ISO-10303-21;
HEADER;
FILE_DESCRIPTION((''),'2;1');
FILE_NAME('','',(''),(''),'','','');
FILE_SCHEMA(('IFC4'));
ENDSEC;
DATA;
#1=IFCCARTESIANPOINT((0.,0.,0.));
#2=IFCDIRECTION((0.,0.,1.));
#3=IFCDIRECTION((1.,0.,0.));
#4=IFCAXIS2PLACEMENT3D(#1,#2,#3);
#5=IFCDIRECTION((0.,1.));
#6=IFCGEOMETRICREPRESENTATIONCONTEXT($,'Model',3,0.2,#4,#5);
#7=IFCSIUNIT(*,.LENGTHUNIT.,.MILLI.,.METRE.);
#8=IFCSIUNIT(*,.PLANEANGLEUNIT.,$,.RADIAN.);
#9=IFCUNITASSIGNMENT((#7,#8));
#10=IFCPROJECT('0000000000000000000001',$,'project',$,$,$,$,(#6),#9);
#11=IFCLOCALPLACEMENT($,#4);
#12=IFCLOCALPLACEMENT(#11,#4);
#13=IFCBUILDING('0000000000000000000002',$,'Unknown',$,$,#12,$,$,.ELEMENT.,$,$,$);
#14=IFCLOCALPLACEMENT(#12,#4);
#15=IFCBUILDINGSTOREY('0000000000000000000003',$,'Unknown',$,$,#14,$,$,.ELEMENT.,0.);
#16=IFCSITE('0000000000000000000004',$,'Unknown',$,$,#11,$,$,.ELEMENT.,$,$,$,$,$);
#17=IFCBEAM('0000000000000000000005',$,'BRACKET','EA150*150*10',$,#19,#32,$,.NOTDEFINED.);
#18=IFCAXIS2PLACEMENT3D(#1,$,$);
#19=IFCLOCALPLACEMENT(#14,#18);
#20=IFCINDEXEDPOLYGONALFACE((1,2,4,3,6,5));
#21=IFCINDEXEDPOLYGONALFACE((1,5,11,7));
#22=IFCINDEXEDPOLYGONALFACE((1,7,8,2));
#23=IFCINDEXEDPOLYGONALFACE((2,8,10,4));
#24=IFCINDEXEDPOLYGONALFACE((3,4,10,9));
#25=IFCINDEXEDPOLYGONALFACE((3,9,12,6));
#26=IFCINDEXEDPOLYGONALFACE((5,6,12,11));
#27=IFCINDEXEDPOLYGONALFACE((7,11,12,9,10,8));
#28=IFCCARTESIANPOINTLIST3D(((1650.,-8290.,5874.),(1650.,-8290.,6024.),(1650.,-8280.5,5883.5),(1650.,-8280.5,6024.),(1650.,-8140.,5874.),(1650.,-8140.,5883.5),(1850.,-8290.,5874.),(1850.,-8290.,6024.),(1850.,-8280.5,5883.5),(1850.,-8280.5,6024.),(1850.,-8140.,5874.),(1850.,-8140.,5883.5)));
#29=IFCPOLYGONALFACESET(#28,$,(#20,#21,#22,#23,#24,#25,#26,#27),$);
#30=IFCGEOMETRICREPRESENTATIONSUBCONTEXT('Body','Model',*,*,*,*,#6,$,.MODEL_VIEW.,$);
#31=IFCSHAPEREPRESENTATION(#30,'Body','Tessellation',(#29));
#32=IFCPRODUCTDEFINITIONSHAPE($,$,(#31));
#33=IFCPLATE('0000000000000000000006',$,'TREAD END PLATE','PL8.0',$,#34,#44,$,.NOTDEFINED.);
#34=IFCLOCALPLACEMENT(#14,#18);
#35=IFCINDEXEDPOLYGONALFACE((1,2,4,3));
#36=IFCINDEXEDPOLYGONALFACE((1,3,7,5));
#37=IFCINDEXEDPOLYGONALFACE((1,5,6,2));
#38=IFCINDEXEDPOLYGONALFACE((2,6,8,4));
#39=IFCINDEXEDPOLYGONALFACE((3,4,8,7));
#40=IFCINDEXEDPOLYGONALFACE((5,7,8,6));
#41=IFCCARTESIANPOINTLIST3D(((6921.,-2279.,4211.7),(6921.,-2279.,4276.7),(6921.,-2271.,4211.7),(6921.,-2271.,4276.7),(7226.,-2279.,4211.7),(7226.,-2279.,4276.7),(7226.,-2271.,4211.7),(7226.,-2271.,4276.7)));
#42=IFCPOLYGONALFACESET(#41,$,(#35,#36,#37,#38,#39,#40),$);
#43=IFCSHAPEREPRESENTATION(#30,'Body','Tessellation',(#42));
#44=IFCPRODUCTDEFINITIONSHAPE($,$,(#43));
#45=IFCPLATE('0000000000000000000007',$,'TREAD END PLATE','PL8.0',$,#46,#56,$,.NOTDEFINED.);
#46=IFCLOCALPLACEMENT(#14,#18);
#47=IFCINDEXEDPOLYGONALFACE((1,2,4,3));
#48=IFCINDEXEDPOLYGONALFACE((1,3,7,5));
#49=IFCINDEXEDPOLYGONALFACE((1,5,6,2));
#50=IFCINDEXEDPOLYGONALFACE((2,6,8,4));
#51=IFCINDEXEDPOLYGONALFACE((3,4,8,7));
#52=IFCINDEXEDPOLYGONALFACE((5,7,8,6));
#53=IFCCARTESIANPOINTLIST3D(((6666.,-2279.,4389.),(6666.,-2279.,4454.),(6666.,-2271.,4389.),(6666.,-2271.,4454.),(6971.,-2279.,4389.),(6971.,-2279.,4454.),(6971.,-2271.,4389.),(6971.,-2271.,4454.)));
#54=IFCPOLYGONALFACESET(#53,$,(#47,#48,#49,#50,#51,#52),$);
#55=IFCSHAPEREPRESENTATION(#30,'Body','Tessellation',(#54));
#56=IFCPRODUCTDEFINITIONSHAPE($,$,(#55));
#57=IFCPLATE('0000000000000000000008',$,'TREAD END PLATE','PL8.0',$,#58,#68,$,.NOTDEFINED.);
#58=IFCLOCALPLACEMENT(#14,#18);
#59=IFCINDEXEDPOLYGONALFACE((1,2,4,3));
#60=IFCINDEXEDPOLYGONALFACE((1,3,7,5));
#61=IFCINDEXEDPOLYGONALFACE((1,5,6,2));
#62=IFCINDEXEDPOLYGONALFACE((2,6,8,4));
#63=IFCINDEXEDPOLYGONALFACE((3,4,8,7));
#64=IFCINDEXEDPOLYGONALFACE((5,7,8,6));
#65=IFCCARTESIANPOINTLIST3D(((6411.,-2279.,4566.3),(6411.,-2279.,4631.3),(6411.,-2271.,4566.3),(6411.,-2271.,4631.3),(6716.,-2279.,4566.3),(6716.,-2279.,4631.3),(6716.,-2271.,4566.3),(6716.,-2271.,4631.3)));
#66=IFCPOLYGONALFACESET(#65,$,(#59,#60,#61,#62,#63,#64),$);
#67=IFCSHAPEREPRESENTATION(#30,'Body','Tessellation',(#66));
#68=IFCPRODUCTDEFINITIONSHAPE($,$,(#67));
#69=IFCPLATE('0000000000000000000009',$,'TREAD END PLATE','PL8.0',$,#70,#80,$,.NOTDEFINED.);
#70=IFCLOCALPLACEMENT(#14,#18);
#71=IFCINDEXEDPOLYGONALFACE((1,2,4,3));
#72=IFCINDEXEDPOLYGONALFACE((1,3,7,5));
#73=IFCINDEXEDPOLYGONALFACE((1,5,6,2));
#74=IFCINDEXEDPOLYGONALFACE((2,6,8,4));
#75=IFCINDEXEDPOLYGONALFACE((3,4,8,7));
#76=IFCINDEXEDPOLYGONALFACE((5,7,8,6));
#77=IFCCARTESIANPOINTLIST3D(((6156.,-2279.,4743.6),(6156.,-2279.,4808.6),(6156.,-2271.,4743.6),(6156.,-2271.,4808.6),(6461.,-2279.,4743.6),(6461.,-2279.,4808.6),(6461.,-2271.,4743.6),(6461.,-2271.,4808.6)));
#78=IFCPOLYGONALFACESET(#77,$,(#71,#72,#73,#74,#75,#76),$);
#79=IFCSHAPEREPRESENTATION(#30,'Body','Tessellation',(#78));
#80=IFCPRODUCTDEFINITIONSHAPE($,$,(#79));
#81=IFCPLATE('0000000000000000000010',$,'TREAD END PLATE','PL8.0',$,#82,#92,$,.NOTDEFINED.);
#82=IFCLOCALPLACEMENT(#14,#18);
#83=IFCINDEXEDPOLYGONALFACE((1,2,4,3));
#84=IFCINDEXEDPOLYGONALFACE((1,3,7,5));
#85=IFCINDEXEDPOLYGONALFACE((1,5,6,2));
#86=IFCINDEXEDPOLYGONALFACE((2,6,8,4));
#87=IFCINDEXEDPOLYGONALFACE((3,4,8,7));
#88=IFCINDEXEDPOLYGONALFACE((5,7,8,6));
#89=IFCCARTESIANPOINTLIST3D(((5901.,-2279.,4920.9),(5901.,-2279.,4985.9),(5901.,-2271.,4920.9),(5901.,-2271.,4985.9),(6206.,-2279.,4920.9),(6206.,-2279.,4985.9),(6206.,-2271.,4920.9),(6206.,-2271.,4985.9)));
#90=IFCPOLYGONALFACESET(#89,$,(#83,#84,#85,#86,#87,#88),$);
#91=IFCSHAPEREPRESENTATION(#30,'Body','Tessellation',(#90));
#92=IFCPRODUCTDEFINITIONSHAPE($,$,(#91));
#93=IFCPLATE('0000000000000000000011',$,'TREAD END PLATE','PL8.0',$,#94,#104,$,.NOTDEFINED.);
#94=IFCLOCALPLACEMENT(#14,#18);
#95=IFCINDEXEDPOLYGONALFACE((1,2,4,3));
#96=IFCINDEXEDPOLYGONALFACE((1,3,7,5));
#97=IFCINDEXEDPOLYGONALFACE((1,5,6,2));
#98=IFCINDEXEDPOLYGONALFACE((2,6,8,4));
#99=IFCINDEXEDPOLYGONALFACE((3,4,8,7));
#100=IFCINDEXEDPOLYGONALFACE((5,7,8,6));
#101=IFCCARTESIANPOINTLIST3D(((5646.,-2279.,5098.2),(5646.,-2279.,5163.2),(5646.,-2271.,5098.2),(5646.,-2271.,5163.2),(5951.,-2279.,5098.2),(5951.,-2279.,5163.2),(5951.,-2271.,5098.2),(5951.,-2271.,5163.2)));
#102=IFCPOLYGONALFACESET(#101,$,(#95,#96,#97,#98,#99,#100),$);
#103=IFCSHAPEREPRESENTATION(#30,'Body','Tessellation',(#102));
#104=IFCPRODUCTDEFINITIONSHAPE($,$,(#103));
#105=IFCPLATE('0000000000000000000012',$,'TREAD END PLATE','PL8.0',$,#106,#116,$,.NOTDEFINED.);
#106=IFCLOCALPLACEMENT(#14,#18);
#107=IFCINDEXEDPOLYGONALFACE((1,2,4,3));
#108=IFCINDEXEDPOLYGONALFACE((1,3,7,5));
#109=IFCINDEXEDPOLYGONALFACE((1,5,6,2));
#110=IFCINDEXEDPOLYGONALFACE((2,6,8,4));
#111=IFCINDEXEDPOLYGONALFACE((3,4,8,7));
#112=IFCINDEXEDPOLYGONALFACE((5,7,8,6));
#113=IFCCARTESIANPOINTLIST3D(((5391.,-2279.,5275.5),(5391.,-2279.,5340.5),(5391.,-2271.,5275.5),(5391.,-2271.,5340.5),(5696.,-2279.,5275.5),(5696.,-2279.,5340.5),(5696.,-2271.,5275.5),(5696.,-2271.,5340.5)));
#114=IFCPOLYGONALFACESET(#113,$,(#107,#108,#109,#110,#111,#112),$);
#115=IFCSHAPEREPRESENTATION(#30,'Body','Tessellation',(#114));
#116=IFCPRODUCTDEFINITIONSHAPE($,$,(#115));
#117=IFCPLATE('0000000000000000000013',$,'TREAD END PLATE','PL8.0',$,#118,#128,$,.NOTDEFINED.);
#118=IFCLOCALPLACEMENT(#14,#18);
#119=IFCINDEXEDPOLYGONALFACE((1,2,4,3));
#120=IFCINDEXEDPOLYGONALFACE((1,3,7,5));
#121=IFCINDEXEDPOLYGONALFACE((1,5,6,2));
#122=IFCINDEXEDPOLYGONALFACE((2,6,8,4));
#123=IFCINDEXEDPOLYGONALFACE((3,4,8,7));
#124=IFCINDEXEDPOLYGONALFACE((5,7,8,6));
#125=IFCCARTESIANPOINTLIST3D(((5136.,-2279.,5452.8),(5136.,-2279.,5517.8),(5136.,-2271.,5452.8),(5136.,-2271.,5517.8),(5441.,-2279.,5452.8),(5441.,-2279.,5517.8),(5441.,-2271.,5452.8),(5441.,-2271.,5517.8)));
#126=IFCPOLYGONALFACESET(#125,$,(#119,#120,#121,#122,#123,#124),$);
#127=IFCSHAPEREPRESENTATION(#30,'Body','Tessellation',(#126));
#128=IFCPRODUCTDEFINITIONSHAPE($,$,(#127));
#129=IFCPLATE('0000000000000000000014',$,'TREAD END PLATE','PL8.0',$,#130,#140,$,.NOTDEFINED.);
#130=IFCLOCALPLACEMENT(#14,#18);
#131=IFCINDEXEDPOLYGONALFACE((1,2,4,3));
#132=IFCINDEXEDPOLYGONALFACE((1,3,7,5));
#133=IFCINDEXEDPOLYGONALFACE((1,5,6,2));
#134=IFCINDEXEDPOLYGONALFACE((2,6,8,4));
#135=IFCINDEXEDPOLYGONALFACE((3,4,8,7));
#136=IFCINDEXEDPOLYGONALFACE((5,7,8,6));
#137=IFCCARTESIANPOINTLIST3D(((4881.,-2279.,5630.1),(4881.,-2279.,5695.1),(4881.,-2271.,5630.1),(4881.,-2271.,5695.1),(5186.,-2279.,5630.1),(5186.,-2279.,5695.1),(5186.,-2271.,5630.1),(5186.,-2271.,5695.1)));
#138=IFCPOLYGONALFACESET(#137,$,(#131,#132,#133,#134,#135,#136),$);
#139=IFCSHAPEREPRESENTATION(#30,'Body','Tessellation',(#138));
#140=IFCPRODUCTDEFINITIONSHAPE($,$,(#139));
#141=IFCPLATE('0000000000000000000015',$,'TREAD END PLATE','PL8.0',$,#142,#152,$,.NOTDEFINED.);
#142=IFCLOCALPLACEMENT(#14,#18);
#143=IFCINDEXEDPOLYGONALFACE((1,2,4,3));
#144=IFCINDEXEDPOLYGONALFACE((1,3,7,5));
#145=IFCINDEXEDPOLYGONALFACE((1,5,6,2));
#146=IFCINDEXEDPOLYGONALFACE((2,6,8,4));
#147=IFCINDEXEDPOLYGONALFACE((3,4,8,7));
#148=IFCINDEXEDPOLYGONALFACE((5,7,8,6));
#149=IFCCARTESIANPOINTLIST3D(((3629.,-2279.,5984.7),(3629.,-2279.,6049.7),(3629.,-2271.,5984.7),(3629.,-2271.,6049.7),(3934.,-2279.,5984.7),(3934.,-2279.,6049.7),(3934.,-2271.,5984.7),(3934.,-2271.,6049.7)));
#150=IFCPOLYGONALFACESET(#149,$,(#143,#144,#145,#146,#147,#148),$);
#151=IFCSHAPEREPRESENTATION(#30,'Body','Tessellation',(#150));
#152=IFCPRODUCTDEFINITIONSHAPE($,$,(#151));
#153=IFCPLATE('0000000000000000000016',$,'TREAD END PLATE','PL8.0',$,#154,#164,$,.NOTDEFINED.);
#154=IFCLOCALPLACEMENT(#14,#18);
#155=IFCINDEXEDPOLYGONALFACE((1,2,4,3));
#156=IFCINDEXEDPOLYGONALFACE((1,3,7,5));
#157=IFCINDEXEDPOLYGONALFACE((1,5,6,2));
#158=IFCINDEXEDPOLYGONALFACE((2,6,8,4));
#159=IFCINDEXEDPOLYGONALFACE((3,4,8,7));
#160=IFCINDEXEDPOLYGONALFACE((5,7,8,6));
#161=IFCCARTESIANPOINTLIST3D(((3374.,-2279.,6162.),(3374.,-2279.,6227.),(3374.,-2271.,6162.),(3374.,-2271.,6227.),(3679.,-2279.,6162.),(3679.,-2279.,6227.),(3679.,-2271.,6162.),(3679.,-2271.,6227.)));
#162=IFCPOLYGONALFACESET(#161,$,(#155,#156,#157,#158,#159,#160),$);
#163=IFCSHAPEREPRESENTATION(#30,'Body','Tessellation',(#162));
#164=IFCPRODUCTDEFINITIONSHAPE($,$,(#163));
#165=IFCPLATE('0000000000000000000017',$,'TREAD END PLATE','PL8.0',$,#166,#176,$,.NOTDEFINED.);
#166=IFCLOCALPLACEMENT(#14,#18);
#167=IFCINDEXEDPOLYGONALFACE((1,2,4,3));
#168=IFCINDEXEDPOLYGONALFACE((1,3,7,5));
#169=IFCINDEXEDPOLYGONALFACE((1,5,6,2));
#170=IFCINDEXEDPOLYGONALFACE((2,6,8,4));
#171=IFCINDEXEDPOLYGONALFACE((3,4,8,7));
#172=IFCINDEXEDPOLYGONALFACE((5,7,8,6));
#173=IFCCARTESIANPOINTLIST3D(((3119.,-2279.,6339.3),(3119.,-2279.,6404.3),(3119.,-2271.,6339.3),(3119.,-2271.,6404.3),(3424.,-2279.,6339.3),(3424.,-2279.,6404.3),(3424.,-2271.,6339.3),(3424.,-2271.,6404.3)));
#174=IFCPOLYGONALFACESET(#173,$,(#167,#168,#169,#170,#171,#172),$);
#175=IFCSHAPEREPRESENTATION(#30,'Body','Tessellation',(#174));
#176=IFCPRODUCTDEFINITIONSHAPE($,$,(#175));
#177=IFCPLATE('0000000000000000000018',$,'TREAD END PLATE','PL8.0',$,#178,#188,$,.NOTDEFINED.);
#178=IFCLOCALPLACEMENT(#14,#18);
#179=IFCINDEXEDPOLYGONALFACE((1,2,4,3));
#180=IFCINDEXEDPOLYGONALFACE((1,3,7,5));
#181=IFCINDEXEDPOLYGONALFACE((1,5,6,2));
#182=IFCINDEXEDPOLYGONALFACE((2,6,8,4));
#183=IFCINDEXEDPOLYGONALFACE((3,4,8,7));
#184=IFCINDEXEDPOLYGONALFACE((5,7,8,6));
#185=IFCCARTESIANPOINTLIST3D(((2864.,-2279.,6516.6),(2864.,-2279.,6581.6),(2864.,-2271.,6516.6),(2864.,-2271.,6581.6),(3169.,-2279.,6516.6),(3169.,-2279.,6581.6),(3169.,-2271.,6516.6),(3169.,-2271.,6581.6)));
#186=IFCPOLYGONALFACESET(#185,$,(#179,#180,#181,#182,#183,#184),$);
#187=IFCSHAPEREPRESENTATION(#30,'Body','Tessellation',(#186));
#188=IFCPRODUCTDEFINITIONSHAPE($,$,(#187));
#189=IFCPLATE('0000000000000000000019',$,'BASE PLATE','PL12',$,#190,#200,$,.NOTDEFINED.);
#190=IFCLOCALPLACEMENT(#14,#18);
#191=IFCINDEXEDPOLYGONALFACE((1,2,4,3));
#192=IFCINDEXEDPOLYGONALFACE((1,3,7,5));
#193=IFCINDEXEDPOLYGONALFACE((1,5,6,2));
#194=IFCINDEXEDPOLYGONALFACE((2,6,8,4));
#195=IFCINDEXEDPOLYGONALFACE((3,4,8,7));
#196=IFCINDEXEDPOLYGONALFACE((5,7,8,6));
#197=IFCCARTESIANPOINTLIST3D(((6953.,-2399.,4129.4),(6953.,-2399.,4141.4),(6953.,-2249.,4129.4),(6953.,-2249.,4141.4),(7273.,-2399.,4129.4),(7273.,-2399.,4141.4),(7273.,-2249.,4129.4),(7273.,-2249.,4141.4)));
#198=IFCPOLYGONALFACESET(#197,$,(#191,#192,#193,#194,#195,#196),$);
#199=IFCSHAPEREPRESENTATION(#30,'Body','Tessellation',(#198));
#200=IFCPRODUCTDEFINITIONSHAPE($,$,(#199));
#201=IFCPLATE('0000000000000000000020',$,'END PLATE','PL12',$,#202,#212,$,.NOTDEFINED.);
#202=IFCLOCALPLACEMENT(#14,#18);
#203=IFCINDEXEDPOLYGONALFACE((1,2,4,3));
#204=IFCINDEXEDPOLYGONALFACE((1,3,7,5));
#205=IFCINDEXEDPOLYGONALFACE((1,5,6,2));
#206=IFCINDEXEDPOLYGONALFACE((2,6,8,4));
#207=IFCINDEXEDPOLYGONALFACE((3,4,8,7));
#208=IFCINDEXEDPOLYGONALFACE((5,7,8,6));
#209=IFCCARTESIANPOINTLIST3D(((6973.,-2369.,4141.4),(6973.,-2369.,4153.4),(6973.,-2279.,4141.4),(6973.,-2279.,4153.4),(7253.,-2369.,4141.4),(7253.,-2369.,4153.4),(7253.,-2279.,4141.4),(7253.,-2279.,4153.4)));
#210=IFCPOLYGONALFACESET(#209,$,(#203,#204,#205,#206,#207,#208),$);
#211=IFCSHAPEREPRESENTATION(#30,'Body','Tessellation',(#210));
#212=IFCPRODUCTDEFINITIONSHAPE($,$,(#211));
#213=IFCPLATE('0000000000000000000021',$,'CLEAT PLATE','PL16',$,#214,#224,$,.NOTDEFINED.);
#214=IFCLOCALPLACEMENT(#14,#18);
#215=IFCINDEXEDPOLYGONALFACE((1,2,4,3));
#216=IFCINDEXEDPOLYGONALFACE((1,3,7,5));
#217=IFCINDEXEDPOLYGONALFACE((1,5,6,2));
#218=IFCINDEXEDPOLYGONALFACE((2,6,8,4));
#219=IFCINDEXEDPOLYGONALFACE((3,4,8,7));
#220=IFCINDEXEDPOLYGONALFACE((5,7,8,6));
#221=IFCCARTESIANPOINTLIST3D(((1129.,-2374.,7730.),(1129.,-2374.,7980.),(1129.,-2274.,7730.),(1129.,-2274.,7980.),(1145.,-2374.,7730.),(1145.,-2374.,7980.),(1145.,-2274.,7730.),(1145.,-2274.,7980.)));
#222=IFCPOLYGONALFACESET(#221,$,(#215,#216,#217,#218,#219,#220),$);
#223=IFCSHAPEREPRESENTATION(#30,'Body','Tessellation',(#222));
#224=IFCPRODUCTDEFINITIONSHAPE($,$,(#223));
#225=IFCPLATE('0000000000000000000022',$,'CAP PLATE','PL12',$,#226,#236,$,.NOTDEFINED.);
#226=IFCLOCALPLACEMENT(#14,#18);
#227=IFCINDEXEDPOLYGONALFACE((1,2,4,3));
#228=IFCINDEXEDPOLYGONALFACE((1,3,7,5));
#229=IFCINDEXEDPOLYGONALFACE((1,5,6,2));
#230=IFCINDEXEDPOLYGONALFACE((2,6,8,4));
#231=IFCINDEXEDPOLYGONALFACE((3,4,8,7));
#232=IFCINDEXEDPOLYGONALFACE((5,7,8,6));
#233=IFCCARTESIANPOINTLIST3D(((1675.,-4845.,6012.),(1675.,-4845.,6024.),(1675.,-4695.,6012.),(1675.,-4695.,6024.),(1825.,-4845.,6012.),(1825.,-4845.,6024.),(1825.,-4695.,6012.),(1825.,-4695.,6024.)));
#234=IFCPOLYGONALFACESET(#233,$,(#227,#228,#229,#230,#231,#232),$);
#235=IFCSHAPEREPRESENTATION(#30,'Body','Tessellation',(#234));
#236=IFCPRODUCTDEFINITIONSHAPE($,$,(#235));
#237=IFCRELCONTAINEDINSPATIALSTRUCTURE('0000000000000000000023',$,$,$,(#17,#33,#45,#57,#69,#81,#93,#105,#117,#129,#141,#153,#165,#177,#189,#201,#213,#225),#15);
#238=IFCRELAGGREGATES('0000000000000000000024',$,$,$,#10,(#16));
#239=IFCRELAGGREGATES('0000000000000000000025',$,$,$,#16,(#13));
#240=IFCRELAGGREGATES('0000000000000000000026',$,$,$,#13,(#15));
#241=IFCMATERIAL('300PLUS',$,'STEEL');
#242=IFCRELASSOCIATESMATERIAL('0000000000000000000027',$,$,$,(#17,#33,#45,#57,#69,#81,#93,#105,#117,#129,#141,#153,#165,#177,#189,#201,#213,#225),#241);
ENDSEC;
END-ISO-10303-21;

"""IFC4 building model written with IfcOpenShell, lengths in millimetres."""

from ifc_helpers import new_model, si_unit, direction, frame, origin_with_axes, place, context, subcontext, project, spatial, line, indexed_curve, outline, extrude, material, element, save


model = new_model("IFC4")

# Units and contexts
model_context = context("Model", 3, precision=0.2, world=origin_with_axes(), true_north=direction((0.0, 1.0)))
body_context = subcontext(model_context, "Body", "Model", "MODEL_VIEW")
ifc_project = project(units=[si_unit("LENGTHUNIT", "METRE", prefix="MILLI"), si_unit("PLANEANGLEUNIT", "RADIAN")], contexts=[model_context])

# Site, building, storey
site_placement = place(None, origin_with_axes())
site = spatial("IfcSite", under=ifc_project, at=site_placement, Name="Unknown", CompositionType="ELEMENT")
building_placement = place(site_placement, origin_with_axes())
building = spatial("IfcBuilding", under=site, at=building_placement, Name="Unknown", CompositionType="ELEMENT")
storey_placement = place(building_placement, origin_with_axes())
storey = spatial("IfcBuildingStorey", under=building, at=storey_placement, Name="Unknown", CompositionType="ELEMENT", Elevation=0.0)

# Beam
ifc_material_1 = material(Name="300PLUS", Category="STEEL")
beam_placement = place(storey_placement, frame((1650.0, -8215.0, 5949.0), z_axis=(0.0, 0.0, 1.0), x_axis=(1.0, 0.0, 0.0)))
element("IfcBeam", 1, at=beam_placement, inside=storey, material=ifc_material_1, Name="BRACKET", Description="EA150*150*10", PredefinedType="NOTDEFINED", context=body_context, shape_type="SolidModel", body=[
    extrude(outline(indexed_curve([(-75.0, -75.0), (75.0, -75.0), (75.0, -65.5), (-65.5, -65.5), (-65.5, 75.0), (-75.0, 75.0)], segments=[line(1, 2, 3, 4, 5, 6, 1)])), frame((0.0, 0.0, 0.0), z_axis=(-1.0, 0.0, 0.0), x_axis=(0.0, 0.0, 1.0)), (0.0, 0.0, -1.0), 200.0),
])

# Plates
for number, where, z_axis, x_axis, name in (
    (2, (6921.0, -2275.0, 4276.7), (0.0, 1.0, 0.0), (1.0, 0.0, 0.0), "TREAD END PLATE"),
    (3, (6666.0, -2275.0, 4454.0), (0.0, 1.0, 0.0), (1.0, 0.0, 0.0), "TREAD END PLATE"),
    (4, (6411.0, -2275.0, 4631.3), (0.0, 1.0, 0.0), (1.0, 0.0, 0.0), "TREAD END PLATE"),
    (5, (6156.0, -2275.0, 4808.6), (0.0, 1.0, 0.0), (1.0, 0.0, 0.0), "TREAD END PLATE"),
    (6, (5901.0, -2275.0, 4985.9), (0.0, 1.0, 0.0), (1.0, 0.0, 0.0), "TREAD END PLATE"),
    (7, (5646.0, -2275.0, 5163.2), (0.0, 1.0, 0.0), (1.0, 0.0, 0.0), "TREAD END PLATE"),
    (8, (5391.0, -2275.0, 5340.5), (0.0, 1.0, 0.0), (1.0, 0.0, 0.0), "TREAD END PLATE"),
    (9, (5136.0, -2275.0, 5517.8), (0.0, 1.0, 0.0), (1.0, 0.0, 0.0), "TREAD END PLATE"),
    (10, (4881.0, -2275.0, 5695.1), (0.0, 1.0, 0.0), (1.0, 0.0, 0.0), "TREAD END PLATE"),
    (11, (3629.0, -2275.0, 6049.7), (0.0, 1.0, 0.0), (1.0, 0.0, 0.0), "TREAD END PLATE"),
    (12, (3374.0, -2275.0, 6227.0), (0.0, 1.0, 0.0), (1.0, 0.0, 0.0), "TREAD END PLATE"),
    (13, (3119.0, -2275.0, 6404.3), (0.0, 1.0, 0.0), (1.0, 0.0, 0.0), "TREAD END PLATE"),
    (14, (2864.0, -2275.0, 6581.6), (0.0, 1.0, 0.0), (1.0, 0.0, 0.0), "TREAD END PLATE"),
):
    element("IfcPlate", number, at=place(storey_placement, frame(where, z_axis=z_axis, x_axis=x_axis)), inside=storey, material=ifc_material_1, Name=name, Description="PL8.0", PredefinedType="NOTDEFINED", context=body_context, shape_type="SolidModel", body=[
        extrude(outline(indexed_curve([(0.0, 0.0), (305.0, 0.0), (305.0, 65.0), (0.0, 65.0)], segments=[line(1, 2, 3, 4, 1)])), frame((0.0, 0.0, 4.0), z_axis=(0.0, 0.0, 1.0), x_axis=(1.0, 0.0, 0.0)), (0.0, 0.0, -1.0), 8.0),
    ])
plate_1_placement = place(storey_placement, frame((6953.0, -2399.0, 4135.4), z_axis=(0.0, 0.0, 1.0), x_axis=(1.0, 0.0, 0.0)))
element("IfcPlate", 15, at=plate_1_placement, inside=storey, material=ifc_material_1, Name="BASE PLATE", Description="PL12", PredefinedType="NOTDEFINED", context=body_context, shape_type="SolidModel", body=[
    extrude(outline(indexed_curve([(0.0, 0.0), (320.0, 0.0), (320.0, 150.0), (0.0, 150.0)], segments=[line(1, 2, 3, 4, 1)])), frame((0.0, 0.0, 6.0), z_axis=(0.0, 0.0, 1.0), x_axis=(1.0, 0.0, 0.0)), (0.0, 0.0, -1.0), 12.0),
])
plate_2_placement = place(storey_placement, frame((6973.0, -2369.0, 4147.4), z_axis=(0.0, 0.0, 1.0), x_axis=(1.0, 0.0, 0.0)))
element("IfcPlate", 16, at=plate_2_placement, inside=storey, material=ifc_material_1, Name="END PLATE", Description="PL12", PredefinedType="NOTDEFINED", context=body_context, shape_type="SolidModel", body=[
    extrude(outline(indexed_curve([(0.0, 0.0), (280.0, 0.0), (280.0, 90.0), (0.0, 90.0)], segments=[line(1, 2, 3, 4, 1)])), frame((0.0, 0.0, 6.0), z_axis=(0.0, 0.0, 1.0), x_axis=(1.0, 0.0, 0.0)), (0.0, 0.0, -1.0), 12.0),
])
plate_3_placement = place(storey_placement, frame((1137.0, -2374.0, 7730.0), z_axis=(1.0, 0.0, 0.0), x_axis=(0.0, 1.0, 0.0)))
element("IfcPlate", 17, at=plate_3_placement, inside=storey, material=ifc_material_1, Name="CLEAT PLATE", Description="PL16", PredefinedType="NOTDEFINED", context=body_context, shape_type="SolidModel", body=[
    extrude(outline(indexed_curve([(0.0, 0.0), (100.0, 0.0), (100.0, 250.0), (0.0, 250.0)], segments=[line(1, 2, 3, 4, 1)])), frame((0.0, 0.0, 8.0), z_axis=(0.0, 0.0, 1.0), x_axis=(1.0, 0.0, 0.0)), (0.0, 0.0, -1.0), 16.0),
])
plate_4_placement = place(storey_placement, frame((1675.0, -4845.0, 6018.0), z_axis=(0.0, 0.0, 1.0), x_axis=(1.0, 0.0, 0.0)))
element("IfcPlate", 18, at=plate_4_placement, inside=storey, material=ifc_material_1, Name="CAP PLATE", Description="PL12", PredefinedType="NOTDEFINED", context=body_context, shape_type="SolidModel", body=[
    extrude(outline(indexed_curve([(0.0, 0.0), (150.0, 0.0), (150.0, 150.0), (0.0, 150.0)], segments=[line(1, 2, 3, 4, 1)])), frame((0.0, 0.0, 6.0), z_axis=(0.0, 0.0, 1.0), x_axis=(1.0, 0.0, 0.0)), (0.0, 0.0, -1.0), 12.0),
])

save(model, "model.ifc")
